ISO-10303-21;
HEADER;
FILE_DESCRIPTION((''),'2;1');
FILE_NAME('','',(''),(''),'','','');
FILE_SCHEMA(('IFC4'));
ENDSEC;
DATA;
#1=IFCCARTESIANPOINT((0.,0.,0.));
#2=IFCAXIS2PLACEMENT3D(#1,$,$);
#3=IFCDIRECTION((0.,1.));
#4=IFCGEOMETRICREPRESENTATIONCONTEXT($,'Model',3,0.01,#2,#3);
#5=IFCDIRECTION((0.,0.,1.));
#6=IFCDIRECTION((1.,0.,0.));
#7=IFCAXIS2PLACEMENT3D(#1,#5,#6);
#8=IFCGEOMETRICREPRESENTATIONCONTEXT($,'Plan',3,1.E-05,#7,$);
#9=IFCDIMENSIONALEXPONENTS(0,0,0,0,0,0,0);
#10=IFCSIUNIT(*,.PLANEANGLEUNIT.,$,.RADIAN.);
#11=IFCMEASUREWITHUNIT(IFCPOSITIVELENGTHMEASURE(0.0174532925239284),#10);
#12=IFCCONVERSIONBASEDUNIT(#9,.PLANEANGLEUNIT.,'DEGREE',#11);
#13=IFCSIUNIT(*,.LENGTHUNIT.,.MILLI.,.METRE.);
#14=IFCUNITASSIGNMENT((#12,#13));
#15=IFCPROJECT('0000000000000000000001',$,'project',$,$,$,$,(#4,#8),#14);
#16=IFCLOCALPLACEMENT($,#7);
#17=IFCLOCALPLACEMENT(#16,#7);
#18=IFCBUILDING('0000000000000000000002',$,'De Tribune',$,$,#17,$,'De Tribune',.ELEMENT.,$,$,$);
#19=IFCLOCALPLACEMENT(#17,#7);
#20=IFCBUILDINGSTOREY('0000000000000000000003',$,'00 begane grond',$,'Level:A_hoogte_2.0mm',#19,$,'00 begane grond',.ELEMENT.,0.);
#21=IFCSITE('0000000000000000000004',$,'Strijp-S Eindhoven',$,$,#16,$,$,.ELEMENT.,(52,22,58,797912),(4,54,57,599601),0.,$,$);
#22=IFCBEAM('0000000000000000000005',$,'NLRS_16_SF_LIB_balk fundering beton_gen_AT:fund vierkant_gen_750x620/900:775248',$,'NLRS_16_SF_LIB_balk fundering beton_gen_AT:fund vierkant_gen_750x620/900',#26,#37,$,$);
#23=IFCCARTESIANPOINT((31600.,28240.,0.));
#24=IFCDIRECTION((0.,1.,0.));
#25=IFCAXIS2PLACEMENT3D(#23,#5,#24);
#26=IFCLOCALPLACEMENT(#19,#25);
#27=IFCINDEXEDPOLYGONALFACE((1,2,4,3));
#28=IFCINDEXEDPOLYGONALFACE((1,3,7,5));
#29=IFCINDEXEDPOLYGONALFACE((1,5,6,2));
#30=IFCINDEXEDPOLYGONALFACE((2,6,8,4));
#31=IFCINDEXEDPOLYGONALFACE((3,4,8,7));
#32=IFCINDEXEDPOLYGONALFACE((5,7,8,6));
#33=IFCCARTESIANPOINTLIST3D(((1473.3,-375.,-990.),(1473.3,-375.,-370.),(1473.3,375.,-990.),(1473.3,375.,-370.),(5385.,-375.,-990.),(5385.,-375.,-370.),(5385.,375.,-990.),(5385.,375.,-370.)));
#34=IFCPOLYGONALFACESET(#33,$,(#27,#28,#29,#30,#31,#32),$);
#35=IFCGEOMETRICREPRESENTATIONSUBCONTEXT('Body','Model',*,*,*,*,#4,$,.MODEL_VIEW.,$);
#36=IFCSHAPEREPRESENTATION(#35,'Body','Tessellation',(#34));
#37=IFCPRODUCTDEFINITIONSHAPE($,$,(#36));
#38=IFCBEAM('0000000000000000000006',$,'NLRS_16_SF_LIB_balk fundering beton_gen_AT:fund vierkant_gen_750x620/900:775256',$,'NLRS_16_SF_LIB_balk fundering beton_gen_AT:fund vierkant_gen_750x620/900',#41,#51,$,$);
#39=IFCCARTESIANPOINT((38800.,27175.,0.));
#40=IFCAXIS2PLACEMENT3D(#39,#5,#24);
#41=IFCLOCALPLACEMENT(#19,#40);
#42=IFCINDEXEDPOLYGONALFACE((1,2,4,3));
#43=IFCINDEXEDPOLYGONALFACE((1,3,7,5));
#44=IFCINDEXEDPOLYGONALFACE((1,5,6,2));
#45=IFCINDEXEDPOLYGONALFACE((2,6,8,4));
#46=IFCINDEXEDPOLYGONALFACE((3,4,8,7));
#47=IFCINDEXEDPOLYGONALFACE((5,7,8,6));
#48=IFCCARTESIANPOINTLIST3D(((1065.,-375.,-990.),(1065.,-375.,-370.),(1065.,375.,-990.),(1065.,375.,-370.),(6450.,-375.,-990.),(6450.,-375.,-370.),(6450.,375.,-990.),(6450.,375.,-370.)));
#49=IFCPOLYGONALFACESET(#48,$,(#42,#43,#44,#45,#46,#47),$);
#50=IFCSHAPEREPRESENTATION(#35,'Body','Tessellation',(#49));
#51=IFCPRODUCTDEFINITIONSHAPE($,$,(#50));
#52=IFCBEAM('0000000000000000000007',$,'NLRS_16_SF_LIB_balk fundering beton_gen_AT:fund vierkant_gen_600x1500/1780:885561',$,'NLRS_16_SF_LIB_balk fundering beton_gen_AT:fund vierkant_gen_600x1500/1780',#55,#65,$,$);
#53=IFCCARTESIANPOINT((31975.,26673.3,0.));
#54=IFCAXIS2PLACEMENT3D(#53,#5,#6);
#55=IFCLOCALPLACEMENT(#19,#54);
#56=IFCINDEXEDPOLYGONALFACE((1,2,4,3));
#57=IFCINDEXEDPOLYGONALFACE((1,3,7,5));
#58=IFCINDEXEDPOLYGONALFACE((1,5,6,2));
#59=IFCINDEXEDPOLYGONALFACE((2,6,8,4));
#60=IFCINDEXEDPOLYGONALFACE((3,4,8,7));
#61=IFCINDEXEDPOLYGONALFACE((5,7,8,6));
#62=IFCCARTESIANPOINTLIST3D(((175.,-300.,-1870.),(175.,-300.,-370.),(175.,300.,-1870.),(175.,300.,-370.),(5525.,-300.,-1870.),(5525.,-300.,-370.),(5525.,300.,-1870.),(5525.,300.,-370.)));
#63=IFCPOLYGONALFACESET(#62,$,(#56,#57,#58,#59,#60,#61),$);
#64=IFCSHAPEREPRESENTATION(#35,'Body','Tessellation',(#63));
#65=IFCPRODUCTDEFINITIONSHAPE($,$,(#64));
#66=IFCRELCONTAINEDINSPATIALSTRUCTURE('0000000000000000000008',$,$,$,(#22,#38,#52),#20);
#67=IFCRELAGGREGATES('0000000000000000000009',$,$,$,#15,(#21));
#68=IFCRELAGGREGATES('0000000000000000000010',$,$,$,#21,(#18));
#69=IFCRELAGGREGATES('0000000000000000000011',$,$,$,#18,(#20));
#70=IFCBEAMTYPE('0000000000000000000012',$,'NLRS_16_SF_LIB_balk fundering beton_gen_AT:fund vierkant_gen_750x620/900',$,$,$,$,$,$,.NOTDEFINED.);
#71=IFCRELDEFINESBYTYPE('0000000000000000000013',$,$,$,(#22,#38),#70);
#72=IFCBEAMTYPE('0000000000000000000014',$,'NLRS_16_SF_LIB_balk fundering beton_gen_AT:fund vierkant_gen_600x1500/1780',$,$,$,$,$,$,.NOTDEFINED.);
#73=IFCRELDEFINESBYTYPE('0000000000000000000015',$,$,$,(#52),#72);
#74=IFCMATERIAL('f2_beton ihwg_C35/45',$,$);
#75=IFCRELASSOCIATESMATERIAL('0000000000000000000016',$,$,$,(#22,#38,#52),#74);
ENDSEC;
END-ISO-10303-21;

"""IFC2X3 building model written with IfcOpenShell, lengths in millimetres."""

from ifc_helpers import new_model, entity, si_unit, converted_unit, direction, frame, frame_2d, origin, origin_with_axes, place, context, subcontext, project, spatial, rectangle, extrude, material, type_object, element, save


model = new_model("IFC2X3")

# Units and contexts
model_context = context("Model", 3, precision=0.01, world=origin(), true_north=direction((0.0, 1.0)))
plan_context = context("Plan", 3, precision=1e-05, world=origin_with_axes())
body_context = subcontext(model_context, "Body", "Model", "MODEL_VIEW")
ifc_project = project(units=[converted_unit("PLANEANGLEUNIT", "DEGREE", entity("IfcPositiveLengthMeasure", 0.0174532925239284), si_unit("PLANEANGLEUNIT", "RADIAN"), dimensions=[0, 0, 0, 0, 0, 0, 0]), si_unit("LENGTHUNIT", "METRE", prefix="MILLI")], contexts=[model_context, plan_context])

# Site, building, storey
site_placement = place(None, origin_with_axes())
site = spatial("IfcSite", under=ifc_project, at=site_placement, Name="Strijp-S Eindhoven", CompositionType="ELEMENT", RefLatitude=(52, 22, 58, 797912), RefLongitude=(4, 54, 57, 599601), RefElevation=0.0)
building_placement = place(site_placement, origin_with_axes())
building = spatial("IfcBuilding", under=site, at=building_placement, Name="De Tribune", LongName="De Tribune", CompositionType="ELEMENT")
storey_placement = place(building_placement, origin_with_axes())
storey = spatial("IfcBuildingStorey", under=building, at=storey_placement, Name="00 begane grond", ObjectType="Level:A_hoogte_2.0mm", LongName="00 begane grond", CompositionType="ELEMENT", Elevation=0.0)

# Beams
ifc_material_1 = material(Name="f2_beton ihwg_C35/45")
beam_type_1 = type_object("IfcBeamType", Name="NLRS_16_SF_LIB_balk fundering beton_gen_AT:fund vierkant_gen_750x620/900", PredefinedType="NOTDEFINED")
beam_1_placement = place(storey_placement, frame((31600.0, 28240.0, 0.0), z_axis=(0.0, 0.0, 1.0), x_axis=(0.0, 1.0, 0.0)))
element("IfcBeam", 1, at=beam_1_placement, inside=storey, type_object=beam_type_1, material=ifc_material_1, Name="NLRS_16_SF_LIB_balk fundering beton_gen_AT:fund vierkant_gen_750x620/900:775248", ObjectType="NLRS_16_SF_LIB_balk fundering beton_gen_AT:fund vierkant_gen_750x620/900", context=body_context, shape_type="SweptSolid", body=[
    extrude(rectangle(XDim=620.0, YDim=750.0, at=frame_2d((0.0, 0.0), x_axis=(1.0, 0.0))), frame((1473.3, 0.0, -680.0), z_axis=(1.0, 0.0, 0.0), x_axis=(0.0, 0.0, -1.0)), (0.0, 0.0, 1.0), 3911.7),
])
beam_2_placement = place(storey_placement, frame((38800.0, 27175.0, 0.0), z_axis=(0.0, 0.0, 1.0), x_axis=(0.0, 1.0, 0.0)))
element("IfcBeam", 2, at=beam_2_placement, inside=storey, type_object=beam_type_1, material=ifc_material_1, Name="NLRS_16_SF_LIB_balk fundering beton_gen_AT:fund vierkant_gen_750x620/900:775256", ObjectType="NLRS_16_SF_LIB_balk fundering beton_gen_AT:fund vierkant_gen_750x620/900", context=body_context, shape_type="SweptSolid", body=[
    extrude(rectangle(XDim=620.0, YDim=750.0, at=frame_2d((0.0, 0.0), x_axis=(1.0, 0.0))), frame((1065.0, 0.0, -680.0), z_axis=(1.0, 0.0, 0.0), x_axis=(0.0, 0.0, -1.0)), (0.0, 0.0, 1.0), 5385.0),
])
beam_type_2 = type_object("IfcBeamType", Name="NLRS_16_SF_LIB_balk fundering beton_gen_AT:fund vierkant_gen_600x1500/1780", PredefinedType="NOTDEFINED")
beam_3_placement = place(storey_placement, frame((31975.0, 26673.3, 0.0), z_axis=(0.0, 0.0, 1.0), x_axis=(1.0, 0.0, 0.0)))
element("IfcBeam", 3, at=beam_3_placement, inside=storey, type_object=beam_type_2, material=ifc_material_1, Name="NLRS_16_SF_LIB_balk fundering beton_gen_AT:fund vierkant_gen_600x1500/1780:885561", ObjectType="NLRS_16_SF_LIB_balk fundering beton_gen_AT:fund vierkant_gen_600x1500/1780", context=body_context, shape_type="SweptSolid", body=[
    extrude(rectangle(XDim=1500.0, YDim=600.0, at=frame_2d((0.0, 0.0), x_axis=(1.0, 0.0))), frame((175.0, 0.0, -1120.0), z_axis=(1.0, 0.0, 0.0), x_axis=(0.0, 0.0, -1.0)), (0.0, 0.0, 1.0), 5350.0),
])

save(model, "model.ifc")
